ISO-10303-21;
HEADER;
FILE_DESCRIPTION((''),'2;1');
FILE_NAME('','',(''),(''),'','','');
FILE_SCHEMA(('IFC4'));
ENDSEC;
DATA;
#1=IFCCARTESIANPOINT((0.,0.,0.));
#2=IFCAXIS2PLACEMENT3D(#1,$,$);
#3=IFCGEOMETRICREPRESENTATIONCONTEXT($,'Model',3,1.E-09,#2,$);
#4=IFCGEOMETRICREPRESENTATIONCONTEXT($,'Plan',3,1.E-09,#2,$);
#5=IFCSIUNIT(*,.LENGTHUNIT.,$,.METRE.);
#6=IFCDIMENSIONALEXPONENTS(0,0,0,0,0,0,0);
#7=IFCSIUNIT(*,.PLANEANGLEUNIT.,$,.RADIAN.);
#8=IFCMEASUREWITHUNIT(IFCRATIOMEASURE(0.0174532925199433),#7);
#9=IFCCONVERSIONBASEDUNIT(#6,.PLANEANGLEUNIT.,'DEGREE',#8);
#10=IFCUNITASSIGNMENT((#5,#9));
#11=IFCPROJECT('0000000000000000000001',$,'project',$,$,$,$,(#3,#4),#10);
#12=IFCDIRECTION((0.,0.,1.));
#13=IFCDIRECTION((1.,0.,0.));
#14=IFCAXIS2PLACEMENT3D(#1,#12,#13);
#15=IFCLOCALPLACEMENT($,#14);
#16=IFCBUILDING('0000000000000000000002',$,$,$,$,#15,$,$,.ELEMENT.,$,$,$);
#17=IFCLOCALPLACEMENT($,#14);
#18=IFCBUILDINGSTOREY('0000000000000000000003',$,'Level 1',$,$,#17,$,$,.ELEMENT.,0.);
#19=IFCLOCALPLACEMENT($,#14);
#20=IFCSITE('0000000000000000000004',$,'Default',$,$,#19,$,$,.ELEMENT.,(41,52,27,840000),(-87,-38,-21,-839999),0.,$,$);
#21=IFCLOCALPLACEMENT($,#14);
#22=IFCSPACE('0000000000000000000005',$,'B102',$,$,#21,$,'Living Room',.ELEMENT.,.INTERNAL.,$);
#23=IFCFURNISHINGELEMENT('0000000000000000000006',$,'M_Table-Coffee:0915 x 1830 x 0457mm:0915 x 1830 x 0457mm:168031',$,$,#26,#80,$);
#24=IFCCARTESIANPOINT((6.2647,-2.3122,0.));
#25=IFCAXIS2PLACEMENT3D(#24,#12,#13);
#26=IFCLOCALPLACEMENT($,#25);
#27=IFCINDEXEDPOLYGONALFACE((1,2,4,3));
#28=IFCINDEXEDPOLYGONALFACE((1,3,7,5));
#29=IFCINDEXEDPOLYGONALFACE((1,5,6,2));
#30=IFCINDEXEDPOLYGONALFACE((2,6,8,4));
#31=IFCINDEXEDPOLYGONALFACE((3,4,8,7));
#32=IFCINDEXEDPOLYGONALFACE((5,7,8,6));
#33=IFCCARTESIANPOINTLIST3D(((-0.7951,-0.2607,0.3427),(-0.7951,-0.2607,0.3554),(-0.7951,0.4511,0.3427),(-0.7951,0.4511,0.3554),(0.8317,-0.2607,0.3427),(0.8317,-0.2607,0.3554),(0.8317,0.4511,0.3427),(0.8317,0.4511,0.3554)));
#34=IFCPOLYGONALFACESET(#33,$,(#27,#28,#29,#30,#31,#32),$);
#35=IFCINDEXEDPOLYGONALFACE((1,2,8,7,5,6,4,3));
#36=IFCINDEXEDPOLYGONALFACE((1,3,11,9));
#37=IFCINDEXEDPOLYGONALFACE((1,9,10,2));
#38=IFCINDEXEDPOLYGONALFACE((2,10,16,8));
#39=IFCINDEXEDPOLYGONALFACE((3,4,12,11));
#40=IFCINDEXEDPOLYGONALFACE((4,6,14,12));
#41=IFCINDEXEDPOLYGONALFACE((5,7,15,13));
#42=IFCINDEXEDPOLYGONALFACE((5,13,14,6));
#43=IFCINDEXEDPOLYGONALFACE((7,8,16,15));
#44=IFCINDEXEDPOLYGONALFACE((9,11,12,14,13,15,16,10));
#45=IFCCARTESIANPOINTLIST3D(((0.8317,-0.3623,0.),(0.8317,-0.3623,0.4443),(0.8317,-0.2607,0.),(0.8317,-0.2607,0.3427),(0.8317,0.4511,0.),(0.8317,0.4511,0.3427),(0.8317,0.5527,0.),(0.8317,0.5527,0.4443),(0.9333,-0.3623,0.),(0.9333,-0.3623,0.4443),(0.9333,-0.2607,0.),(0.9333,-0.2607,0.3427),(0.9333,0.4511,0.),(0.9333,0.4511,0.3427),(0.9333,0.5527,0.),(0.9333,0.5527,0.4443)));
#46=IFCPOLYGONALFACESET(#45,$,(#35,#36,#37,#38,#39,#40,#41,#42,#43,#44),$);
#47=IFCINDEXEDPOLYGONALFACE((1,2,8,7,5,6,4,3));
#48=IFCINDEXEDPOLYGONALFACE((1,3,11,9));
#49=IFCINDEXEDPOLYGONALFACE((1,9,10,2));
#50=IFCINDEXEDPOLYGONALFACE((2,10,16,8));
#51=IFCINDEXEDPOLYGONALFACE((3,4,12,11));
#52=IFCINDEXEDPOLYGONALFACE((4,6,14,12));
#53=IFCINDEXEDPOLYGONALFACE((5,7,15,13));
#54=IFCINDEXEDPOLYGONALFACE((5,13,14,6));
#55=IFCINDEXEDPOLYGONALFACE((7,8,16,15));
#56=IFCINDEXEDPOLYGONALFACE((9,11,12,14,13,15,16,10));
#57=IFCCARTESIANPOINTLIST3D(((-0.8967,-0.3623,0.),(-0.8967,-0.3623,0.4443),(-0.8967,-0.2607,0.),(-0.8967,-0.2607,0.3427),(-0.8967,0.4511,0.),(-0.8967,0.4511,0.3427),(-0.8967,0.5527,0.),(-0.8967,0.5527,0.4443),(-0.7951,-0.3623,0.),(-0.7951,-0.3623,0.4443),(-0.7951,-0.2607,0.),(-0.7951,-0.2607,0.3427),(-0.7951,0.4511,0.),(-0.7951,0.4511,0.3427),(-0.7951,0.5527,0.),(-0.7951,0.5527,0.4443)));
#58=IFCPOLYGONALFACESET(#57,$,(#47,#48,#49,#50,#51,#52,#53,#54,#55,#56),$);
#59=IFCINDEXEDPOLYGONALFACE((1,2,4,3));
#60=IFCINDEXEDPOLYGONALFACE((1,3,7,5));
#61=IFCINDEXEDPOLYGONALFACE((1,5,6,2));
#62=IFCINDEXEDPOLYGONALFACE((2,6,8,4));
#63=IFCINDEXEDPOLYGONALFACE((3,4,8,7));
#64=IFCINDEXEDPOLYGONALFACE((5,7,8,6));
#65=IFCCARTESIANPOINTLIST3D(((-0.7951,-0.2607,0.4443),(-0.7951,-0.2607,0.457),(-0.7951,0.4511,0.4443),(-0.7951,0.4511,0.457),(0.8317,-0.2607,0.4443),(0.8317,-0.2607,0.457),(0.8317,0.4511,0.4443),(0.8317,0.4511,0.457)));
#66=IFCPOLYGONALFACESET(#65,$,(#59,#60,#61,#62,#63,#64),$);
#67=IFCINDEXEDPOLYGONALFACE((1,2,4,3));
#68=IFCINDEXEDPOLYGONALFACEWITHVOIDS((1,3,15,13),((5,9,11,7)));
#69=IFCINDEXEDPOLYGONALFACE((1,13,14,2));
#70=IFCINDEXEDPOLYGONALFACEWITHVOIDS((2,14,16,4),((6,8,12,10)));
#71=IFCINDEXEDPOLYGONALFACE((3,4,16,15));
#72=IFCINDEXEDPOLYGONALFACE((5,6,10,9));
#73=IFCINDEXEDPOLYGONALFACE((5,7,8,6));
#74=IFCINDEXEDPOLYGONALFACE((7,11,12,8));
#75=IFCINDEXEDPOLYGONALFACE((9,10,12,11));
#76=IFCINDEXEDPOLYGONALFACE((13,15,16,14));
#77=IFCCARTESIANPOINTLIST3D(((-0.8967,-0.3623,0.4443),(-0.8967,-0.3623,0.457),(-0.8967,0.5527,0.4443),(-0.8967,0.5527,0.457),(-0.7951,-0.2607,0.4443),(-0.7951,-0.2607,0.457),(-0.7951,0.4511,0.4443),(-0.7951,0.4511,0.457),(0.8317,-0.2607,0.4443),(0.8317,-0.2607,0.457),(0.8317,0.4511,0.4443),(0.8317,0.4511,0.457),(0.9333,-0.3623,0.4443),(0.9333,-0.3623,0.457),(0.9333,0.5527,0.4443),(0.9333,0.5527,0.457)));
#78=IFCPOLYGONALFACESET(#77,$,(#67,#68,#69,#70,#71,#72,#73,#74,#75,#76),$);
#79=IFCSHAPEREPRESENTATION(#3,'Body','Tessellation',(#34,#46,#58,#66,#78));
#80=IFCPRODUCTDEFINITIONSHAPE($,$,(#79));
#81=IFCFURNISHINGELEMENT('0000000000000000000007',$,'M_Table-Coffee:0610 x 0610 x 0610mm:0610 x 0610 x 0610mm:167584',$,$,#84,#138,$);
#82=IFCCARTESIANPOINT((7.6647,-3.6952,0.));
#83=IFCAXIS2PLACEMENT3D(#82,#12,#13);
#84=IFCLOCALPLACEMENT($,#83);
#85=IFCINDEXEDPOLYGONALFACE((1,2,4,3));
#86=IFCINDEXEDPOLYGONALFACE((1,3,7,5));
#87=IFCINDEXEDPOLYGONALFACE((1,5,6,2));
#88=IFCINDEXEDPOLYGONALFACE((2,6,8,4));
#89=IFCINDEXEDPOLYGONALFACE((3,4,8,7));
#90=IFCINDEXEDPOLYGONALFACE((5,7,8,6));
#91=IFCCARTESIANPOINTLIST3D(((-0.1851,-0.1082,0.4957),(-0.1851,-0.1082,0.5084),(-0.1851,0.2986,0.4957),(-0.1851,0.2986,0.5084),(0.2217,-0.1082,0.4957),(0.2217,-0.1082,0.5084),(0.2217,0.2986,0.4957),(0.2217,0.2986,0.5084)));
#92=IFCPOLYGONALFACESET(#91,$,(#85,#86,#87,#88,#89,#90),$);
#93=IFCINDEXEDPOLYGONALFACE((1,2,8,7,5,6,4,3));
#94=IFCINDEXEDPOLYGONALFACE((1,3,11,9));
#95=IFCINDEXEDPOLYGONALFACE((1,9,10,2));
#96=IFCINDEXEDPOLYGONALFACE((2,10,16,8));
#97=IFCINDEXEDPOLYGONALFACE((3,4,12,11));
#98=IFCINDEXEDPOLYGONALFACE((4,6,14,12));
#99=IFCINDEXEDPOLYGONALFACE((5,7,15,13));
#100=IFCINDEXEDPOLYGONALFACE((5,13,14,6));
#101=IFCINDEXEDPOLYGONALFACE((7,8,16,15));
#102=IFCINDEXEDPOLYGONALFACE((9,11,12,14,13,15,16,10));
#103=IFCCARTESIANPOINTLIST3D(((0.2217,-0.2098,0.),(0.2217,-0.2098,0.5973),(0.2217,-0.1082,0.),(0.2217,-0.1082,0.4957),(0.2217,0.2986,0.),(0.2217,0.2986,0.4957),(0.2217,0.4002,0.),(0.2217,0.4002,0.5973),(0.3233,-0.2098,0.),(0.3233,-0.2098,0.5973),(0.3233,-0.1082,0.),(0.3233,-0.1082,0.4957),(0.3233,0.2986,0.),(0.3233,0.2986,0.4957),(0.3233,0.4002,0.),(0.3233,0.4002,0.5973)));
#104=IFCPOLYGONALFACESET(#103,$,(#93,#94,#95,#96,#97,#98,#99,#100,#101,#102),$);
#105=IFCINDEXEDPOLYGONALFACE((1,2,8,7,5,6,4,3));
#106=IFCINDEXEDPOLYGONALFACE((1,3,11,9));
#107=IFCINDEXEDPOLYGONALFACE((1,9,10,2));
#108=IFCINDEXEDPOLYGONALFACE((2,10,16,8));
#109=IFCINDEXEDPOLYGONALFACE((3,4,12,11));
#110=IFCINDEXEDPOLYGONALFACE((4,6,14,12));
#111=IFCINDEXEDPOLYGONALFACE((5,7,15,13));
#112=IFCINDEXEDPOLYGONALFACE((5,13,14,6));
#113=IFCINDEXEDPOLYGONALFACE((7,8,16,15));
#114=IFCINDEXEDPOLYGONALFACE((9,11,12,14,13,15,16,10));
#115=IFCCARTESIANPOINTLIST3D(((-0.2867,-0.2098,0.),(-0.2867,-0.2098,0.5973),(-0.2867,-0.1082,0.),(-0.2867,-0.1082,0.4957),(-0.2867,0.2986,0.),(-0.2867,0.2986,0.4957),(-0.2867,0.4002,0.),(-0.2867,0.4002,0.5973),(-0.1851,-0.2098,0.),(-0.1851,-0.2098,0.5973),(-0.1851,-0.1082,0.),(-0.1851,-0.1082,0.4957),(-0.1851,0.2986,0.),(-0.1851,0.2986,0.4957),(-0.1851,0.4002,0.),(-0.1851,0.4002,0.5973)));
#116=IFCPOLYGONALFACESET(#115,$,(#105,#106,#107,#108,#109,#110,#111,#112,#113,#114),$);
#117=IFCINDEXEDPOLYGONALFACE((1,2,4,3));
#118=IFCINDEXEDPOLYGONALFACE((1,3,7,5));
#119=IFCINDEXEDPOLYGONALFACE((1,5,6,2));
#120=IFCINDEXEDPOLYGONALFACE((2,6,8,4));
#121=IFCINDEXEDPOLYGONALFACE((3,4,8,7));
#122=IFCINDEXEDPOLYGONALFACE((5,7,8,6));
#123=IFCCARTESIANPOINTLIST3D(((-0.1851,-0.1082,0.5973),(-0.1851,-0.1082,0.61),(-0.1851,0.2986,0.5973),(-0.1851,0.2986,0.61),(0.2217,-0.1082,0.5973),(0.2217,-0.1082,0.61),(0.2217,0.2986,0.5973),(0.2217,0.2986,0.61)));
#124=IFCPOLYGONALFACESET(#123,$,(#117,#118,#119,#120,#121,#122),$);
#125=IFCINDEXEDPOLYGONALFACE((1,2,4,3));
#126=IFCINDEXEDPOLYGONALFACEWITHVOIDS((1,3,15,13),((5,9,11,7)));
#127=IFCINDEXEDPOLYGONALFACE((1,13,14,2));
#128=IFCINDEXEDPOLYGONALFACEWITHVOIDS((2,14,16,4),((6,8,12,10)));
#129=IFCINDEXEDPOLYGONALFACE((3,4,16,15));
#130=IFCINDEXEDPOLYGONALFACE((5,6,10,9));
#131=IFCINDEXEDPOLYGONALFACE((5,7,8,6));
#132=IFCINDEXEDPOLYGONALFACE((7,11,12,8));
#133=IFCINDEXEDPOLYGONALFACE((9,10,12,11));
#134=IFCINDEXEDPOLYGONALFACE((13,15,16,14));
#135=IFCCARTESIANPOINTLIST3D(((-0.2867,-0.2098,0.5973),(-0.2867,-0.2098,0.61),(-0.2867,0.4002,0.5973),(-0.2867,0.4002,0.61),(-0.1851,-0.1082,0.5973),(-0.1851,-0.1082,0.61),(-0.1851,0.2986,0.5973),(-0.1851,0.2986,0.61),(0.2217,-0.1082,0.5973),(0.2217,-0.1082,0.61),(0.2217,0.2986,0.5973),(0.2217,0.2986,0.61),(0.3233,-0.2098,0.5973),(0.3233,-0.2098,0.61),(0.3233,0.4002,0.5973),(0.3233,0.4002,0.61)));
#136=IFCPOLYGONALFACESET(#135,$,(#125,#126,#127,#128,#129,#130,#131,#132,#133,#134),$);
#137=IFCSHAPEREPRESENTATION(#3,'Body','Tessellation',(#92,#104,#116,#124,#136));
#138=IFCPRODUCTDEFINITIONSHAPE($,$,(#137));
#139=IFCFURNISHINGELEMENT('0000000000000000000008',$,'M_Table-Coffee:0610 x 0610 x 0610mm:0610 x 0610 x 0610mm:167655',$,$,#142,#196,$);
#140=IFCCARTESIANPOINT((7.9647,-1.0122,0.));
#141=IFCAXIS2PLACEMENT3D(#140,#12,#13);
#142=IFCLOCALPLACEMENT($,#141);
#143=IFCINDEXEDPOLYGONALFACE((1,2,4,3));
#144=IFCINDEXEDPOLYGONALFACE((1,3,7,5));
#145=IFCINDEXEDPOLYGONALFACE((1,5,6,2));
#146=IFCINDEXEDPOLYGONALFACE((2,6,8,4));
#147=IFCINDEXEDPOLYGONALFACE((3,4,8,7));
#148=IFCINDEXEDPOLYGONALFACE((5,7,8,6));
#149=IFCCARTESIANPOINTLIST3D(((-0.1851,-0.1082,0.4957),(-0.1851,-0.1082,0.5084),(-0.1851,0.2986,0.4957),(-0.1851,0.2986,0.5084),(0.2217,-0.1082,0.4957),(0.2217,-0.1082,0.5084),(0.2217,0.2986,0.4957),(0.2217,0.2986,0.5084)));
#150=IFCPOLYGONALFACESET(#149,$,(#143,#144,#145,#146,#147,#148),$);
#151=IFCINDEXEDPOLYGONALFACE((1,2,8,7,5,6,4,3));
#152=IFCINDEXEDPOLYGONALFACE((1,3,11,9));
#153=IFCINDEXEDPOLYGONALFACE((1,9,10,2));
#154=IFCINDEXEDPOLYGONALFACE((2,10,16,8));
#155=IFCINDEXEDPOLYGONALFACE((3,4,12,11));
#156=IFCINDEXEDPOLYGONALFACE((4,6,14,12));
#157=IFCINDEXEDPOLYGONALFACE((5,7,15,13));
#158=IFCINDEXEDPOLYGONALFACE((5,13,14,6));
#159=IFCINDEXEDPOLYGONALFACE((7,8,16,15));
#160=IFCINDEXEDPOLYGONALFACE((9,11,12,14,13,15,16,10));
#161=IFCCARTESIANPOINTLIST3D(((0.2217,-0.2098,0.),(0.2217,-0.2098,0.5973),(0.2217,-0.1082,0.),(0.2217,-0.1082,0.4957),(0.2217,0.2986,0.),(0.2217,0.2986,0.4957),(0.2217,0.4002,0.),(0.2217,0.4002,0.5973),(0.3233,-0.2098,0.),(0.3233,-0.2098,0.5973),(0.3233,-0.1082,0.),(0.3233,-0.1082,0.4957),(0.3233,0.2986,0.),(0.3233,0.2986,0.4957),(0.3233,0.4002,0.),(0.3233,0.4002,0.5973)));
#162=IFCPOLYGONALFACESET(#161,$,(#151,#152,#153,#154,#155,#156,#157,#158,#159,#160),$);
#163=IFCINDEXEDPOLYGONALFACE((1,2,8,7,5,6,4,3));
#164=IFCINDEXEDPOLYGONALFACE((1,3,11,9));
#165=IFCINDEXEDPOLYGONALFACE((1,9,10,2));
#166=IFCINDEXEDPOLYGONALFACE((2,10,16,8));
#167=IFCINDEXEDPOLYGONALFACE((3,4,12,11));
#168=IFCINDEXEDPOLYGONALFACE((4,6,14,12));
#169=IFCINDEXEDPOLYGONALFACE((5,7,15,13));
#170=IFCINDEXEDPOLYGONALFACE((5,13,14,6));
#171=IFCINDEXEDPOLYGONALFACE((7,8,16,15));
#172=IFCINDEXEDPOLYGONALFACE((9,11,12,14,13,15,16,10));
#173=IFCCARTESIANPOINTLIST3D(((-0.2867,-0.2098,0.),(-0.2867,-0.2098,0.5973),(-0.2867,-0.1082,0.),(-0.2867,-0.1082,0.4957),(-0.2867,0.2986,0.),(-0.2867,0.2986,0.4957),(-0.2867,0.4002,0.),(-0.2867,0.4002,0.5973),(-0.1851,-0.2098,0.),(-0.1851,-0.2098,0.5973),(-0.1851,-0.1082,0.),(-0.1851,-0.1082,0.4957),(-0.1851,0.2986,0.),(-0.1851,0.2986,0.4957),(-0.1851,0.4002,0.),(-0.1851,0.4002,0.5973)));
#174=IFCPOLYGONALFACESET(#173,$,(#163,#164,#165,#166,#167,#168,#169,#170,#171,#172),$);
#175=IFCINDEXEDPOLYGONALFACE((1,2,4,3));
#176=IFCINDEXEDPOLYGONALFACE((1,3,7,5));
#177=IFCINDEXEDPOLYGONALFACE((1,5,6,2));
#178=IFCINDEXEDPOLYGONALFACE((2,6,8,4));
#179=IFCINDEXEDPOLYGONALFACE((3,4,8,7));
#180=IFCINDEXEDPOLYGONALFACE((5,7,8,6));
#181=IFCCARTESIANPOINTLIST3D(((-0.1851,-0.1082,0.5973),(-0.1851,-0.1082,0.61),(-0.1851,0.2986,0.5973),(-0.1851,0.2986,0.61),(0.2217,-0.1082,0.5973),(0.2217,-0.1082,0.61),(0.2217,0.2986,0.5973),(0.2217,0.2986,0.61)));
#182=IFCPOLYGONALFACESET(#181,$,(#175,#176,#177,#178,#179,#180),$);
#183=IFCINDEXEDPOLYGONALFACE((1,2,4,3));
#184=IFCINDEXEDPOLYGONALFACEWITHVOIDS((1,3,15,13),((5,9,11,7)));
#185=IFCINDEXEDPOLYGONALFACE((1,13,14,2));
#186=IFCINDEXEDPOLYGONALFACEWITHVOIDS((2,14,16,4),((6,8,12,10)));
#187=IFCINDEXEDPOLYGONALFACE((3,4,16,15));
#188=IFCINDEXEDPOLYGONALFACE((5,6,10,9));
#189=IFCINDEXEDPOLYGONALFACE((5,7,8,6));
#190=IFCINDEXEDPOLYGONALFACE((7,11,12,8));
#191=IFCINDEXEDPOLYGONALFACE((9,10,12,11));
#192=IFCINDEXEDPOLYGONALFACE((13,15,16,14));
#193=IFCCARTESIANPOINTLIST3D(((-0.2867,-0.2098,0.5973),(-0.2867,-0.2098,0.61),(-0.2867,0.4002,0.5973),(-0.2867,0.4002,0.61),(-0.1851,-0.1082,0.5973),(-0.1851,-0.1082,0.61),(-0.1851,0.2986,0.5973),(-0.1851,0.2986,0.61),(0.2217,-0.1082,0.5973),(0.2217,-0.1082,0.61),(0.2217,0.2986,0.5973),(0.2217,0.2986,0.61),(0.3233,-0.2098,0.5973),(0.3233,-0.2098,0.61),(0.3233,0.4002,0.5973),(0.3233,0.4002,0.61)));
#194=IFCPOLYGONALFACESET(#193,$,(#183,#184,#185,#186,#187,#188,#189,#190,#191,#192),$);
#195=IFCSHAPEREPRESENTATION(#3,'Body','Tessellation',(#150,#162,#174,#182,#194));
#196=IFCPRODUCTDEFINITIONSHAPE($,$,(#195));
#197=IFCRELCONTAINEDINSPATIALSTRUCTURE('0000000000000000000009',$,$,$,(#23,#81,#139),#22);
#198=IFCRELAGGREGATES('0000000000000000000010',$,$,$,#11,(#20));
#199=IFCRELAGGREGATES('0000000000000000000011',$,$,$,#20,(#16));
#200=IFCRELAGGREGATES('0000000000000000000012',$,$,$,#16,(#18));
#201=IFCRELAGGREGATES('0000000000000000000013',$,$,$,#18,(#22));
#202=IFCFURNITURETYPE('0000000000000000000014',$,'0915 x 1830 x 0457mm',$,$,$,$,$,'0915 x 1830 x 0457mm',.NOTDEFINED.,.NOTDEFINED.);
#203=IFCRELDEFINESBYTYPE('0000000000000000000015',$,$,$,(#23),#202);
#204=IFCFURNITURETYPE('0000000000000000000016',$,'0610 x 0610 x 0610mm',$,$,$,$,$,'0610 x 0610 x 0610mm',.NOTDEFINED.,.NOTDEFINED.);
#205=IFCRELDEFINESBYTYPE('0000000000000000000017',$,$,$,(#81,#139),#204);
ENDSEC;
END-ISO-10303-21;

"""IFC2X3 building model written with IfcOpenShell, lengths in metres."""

from ifc_helpers import new_model, entity, si_unit, converted_unit, frame, origin, origin_with_axes, origin_2d_with_axis, place, context, project, spatial, polyline, rectangle, outline, extrude, source, transform, mapped, type_object, type_shapes, element, save


model = new_model("IFC2X3")

# Units and contexts
model_context = context("Model", 3, precision=1e-09, world=origin())
plan_context = context("Plan", 3, precision=1e-09, world=origin())
ifc_project = project(units=[si_unit("LENGTHUNIT", "METRE"), converted_unit("PLANEANGLEUNIT", "DEGREE", entity("IfcRatioMeasure", 0.0174532925199433), si_unit("PLANEANGLEUNIT", "RADIAN"), dimensions=[0, 0, 0, 0, 0, 0, 0])], contexts=[model_context, plan_context])

# Site, building, storey, space
site_placement = place(None, origin_with_axes())
site = spatial("IfcSite", under=ifc_project, at=site_placement, Name="Default", CompositionType="ELEMENT", RefLatitude=(41, 52, 27, 840000), RefLongitude=(-87, -38, -21, -839999), RefElevation=0.0)
building_placement = place(None, origin_with_axes())
building = spatial("IfcBuilding", under=site, at=building_placement, CompositionType="ELEMENT")
storey_placement = place(None, origin_with_axes())
storey = spatial("IfcBuildingStorey", under=building, at=storey_placement, Name="Level 1", CompositionType="ELEMENT", Elevation=0.0)
space_placement = place(None, origin_with_axes())
space = spatial("IfcSpace", under=storey, at=space_placement, Name="B102", LongName="Living Room", CompositionType="ELEMENT", InteriorOrExteriorSpace="INTERNAL")

# Furnishing elements
furniture_type_1 = type_object("IfcFurnitureType", Name="0915 x 1830 x 0457mm", ElementType="0915 x 1830 x 0457mm", AssemblyPlace="NOTDEFINED")
shared_shape_1 = source(origin(), model_context, "Body", "SweptSolid", [
    extrude(rectangle(XDim=1.6268, YDim=0.7118, at=origin_2d_with_axis()), frame((0.0183, 0.0952, 0.3427), z_axis=(0.0, 0.0, 1.0), x_axis=(-1.0, 0.0, 0.0)), (0.0, 0.0, 1.0), 0.0127),
    extrude(outline(polyline([(-0.1967, -0.4575), (0.2475, -0.4575), (0.2475, 0.4575), (-0.1967, 0.4575), (-0.1967, 0.3559), (0.146, 0.3559), (0.146, -0.3559), (-0.1967, -0.3559), (-0.1967, -0.4575)])), frame((0.8317, 0.0952, 0.1967), z_axis=(1.0, 0.0, 0.0), x_axis=(0.0, 0.0, 1.0)), (0.0, 0.0, 1.0), 0.1016),
    extrude(outline(polyline([(-0.4575, -0.2476), (0.4575, -0.2476), (0.4575, 0.1968), (0.3559, 0.1968), (0.3559, -0.1459), (-0.3559, -0.1459), (-0.3559, 0.1968), (-0.4575, 0.1968), (-0.4575, -0.2476)])), frame((-0.8967, 0.0952, 0.1968), z_axis=(1.0, 0.0, 0.0), x_axis=(0.0, -1.0, 0.0)), (0.0, 0.0, 1.0), 0.1016),
    extrude(rectangle(XDim=1.6268, YDim=0.7118, at=origin_2d_with_axis()), frame((0.0183, 0.0952, 0.4443), z_axis=(0.0, 0.0, 1.0), x_axis=(-1.0, 0.0, 0.0)), (0.0, 0.0, 1.0), 0.0127),
    extrude(outline(polyline([(-0.915, -0.4575), (0.915, -0.4575), (0.915, 0.4575), (-0.915, 0.4575), (-0.915, -0.4575)]), holes=[polyline([(-0.8134, -0.3559), (-0.8134, 0.3559), (0.8134, 0.3559), (0.8134, -0.3559), (-0.8134, -0.3559)])]), frame((0.0183, 0.0952, 0.4443), z_axis=(0.0, 0.0, 1.0), x_axis=(-1.0, 0.0, 0.0)), (0.0, 0.0, 1.0), 0.0127),
])
type_shapes(furniture_type_1, [shared_shape_1])
furnishing_placement = place(None, frame((6.2647, -2.3122, 0.0), z_axis=(0.0, 0.0, 1.0), x_axis=(1.0, 0.0, 0.0)))
element("IfcFurnishingElement", 1, at=furnishing_placement, inside=space, type_object=furniture_type_1, Name="M_Table-Coffee:0915 x 1830 x 0457mm:0915 x 1830 x 0457mm:168031", context=model_context, shape_type="MappedRepresentation", body=[
    mapped(shared_shape_1, transform((0.0, 0.0, 0.0), scale=1.0)),
])
furniture_type_2 = type_object("IfcFurnitureType", Name="0610 x 0610 x 0610mm", ElementType="0610 x 0610 x 0610mm", AssemblyPlace="NOTDEFINED")
shared_shape_2 = source(origin(), model_context, "Body", "SweptSolid", [
    extrude(rectangle(XDim=0.4068, YDim=0.4068, at=origin_2d_with_axis()), frame((0.0183, 0.0952, 0.4957), z_axis=(0.0, 0.0, 1.0), x_axis=(-1.0, 0.0, 0.0)), (0.0, 0.0, 1.0), 0.0127),
    extrude(outline(polyline([(-0.2732, -0.305), (0.324, -0.305), (0.324, 0.305), (-0.2732, 0.305), (-0.2732, 0.2034), (0.2225, 0.2034), (0.2225, -0.2034), (-0.2732, -0.2034), (-0.2732, -0.305)])), frame((0.2217, 0.0952, 0.2732), z_axis=(1.0, 0.0, 0.0), x_axis=(0.0, 0.0, 1.0)), (0.0, 0.0, 1.0), 0.1016),
    extrude(outline(polyline([(-0.305, -0.3241), (0.305, -0.3241), (0.305, 0.2733), (0.2034, 0.2733), (0.2034, -0.2224), (-0.2034, -0.2224), (-0.2034, 0.2733), (-0.305, 0.2733), (-0.305, -0.3241)])), frame((-0.2867, 0.0952, 0.2733), z_axis=(1.0, 0.0, 0.0), x_axis=(0.0, -1.0, 0.0)), (0.0, 0.0, 1.0), 0.1016),
    extrude(rectangle(XDim=0.4068, YDim=0.4068, at=origin_2d_with_axis()), frame((0.0183, 0.0952, 0.5973), z_axis=(0.0, 0.0, 1.0), x_axis=(-1.0, 0.0, 0.0)), (0.0, 0.0, 1.0), 0.0127),
    extrude(outline(polyline([(-0.305, -0.305), (0.305, -0.305), (0.305, 0.305), (-0.305, 0.305), (-0.305, -0.305)]), holes=[polyline([(-0.2034, -0.2034), (-0.2034, 0.2034), (0.2034, 0.2034), (0.2034, -0.2034), (-0.2034, -0.2034)])]), frame((0.0183, 0.0952, 0.5973), z_axis=(0.0, 0.0, 1.0), x_axis=(-1.0, 0.0, 0.0)), (0.0, 0.0, 1.0), 0.0127),
])
type_shapes(furniture_type_2, [shared_shape_2])
for number, where, z_axis, x_axis, name in (
    (2, (7.6647, -3.6952, 0.0), (0.0, 0.0, 1.0), (1.0, 0.0, 0.0), "M_Table-Coffee:0610 x 0610 x 0610mm:0610 x 0610 x 0610mm:167584"),
    (3, (7.9647, -1.0122, 0.0), (0.0, 0.0, 1.0), (1.0, 0.0, 0.0), "M_Table-Coffee:0610 x 0610 x 0610mm:0610 x 0610 x 0610mm:167655"),
):
    element("IfcFurnishingElement", number, at=place(None, frame(where, z_axis=z_axis, x_axis=x_axis)), inside=space, type_object=furniture_type_2, Name=name, context=model_context, shape_type="MappedRepresentation", body=[
        mapped(shared_shape_2, transform((0.0, 0.0, 0.0), scale=1.0)),
    ])

save(model, "model.ifc")
